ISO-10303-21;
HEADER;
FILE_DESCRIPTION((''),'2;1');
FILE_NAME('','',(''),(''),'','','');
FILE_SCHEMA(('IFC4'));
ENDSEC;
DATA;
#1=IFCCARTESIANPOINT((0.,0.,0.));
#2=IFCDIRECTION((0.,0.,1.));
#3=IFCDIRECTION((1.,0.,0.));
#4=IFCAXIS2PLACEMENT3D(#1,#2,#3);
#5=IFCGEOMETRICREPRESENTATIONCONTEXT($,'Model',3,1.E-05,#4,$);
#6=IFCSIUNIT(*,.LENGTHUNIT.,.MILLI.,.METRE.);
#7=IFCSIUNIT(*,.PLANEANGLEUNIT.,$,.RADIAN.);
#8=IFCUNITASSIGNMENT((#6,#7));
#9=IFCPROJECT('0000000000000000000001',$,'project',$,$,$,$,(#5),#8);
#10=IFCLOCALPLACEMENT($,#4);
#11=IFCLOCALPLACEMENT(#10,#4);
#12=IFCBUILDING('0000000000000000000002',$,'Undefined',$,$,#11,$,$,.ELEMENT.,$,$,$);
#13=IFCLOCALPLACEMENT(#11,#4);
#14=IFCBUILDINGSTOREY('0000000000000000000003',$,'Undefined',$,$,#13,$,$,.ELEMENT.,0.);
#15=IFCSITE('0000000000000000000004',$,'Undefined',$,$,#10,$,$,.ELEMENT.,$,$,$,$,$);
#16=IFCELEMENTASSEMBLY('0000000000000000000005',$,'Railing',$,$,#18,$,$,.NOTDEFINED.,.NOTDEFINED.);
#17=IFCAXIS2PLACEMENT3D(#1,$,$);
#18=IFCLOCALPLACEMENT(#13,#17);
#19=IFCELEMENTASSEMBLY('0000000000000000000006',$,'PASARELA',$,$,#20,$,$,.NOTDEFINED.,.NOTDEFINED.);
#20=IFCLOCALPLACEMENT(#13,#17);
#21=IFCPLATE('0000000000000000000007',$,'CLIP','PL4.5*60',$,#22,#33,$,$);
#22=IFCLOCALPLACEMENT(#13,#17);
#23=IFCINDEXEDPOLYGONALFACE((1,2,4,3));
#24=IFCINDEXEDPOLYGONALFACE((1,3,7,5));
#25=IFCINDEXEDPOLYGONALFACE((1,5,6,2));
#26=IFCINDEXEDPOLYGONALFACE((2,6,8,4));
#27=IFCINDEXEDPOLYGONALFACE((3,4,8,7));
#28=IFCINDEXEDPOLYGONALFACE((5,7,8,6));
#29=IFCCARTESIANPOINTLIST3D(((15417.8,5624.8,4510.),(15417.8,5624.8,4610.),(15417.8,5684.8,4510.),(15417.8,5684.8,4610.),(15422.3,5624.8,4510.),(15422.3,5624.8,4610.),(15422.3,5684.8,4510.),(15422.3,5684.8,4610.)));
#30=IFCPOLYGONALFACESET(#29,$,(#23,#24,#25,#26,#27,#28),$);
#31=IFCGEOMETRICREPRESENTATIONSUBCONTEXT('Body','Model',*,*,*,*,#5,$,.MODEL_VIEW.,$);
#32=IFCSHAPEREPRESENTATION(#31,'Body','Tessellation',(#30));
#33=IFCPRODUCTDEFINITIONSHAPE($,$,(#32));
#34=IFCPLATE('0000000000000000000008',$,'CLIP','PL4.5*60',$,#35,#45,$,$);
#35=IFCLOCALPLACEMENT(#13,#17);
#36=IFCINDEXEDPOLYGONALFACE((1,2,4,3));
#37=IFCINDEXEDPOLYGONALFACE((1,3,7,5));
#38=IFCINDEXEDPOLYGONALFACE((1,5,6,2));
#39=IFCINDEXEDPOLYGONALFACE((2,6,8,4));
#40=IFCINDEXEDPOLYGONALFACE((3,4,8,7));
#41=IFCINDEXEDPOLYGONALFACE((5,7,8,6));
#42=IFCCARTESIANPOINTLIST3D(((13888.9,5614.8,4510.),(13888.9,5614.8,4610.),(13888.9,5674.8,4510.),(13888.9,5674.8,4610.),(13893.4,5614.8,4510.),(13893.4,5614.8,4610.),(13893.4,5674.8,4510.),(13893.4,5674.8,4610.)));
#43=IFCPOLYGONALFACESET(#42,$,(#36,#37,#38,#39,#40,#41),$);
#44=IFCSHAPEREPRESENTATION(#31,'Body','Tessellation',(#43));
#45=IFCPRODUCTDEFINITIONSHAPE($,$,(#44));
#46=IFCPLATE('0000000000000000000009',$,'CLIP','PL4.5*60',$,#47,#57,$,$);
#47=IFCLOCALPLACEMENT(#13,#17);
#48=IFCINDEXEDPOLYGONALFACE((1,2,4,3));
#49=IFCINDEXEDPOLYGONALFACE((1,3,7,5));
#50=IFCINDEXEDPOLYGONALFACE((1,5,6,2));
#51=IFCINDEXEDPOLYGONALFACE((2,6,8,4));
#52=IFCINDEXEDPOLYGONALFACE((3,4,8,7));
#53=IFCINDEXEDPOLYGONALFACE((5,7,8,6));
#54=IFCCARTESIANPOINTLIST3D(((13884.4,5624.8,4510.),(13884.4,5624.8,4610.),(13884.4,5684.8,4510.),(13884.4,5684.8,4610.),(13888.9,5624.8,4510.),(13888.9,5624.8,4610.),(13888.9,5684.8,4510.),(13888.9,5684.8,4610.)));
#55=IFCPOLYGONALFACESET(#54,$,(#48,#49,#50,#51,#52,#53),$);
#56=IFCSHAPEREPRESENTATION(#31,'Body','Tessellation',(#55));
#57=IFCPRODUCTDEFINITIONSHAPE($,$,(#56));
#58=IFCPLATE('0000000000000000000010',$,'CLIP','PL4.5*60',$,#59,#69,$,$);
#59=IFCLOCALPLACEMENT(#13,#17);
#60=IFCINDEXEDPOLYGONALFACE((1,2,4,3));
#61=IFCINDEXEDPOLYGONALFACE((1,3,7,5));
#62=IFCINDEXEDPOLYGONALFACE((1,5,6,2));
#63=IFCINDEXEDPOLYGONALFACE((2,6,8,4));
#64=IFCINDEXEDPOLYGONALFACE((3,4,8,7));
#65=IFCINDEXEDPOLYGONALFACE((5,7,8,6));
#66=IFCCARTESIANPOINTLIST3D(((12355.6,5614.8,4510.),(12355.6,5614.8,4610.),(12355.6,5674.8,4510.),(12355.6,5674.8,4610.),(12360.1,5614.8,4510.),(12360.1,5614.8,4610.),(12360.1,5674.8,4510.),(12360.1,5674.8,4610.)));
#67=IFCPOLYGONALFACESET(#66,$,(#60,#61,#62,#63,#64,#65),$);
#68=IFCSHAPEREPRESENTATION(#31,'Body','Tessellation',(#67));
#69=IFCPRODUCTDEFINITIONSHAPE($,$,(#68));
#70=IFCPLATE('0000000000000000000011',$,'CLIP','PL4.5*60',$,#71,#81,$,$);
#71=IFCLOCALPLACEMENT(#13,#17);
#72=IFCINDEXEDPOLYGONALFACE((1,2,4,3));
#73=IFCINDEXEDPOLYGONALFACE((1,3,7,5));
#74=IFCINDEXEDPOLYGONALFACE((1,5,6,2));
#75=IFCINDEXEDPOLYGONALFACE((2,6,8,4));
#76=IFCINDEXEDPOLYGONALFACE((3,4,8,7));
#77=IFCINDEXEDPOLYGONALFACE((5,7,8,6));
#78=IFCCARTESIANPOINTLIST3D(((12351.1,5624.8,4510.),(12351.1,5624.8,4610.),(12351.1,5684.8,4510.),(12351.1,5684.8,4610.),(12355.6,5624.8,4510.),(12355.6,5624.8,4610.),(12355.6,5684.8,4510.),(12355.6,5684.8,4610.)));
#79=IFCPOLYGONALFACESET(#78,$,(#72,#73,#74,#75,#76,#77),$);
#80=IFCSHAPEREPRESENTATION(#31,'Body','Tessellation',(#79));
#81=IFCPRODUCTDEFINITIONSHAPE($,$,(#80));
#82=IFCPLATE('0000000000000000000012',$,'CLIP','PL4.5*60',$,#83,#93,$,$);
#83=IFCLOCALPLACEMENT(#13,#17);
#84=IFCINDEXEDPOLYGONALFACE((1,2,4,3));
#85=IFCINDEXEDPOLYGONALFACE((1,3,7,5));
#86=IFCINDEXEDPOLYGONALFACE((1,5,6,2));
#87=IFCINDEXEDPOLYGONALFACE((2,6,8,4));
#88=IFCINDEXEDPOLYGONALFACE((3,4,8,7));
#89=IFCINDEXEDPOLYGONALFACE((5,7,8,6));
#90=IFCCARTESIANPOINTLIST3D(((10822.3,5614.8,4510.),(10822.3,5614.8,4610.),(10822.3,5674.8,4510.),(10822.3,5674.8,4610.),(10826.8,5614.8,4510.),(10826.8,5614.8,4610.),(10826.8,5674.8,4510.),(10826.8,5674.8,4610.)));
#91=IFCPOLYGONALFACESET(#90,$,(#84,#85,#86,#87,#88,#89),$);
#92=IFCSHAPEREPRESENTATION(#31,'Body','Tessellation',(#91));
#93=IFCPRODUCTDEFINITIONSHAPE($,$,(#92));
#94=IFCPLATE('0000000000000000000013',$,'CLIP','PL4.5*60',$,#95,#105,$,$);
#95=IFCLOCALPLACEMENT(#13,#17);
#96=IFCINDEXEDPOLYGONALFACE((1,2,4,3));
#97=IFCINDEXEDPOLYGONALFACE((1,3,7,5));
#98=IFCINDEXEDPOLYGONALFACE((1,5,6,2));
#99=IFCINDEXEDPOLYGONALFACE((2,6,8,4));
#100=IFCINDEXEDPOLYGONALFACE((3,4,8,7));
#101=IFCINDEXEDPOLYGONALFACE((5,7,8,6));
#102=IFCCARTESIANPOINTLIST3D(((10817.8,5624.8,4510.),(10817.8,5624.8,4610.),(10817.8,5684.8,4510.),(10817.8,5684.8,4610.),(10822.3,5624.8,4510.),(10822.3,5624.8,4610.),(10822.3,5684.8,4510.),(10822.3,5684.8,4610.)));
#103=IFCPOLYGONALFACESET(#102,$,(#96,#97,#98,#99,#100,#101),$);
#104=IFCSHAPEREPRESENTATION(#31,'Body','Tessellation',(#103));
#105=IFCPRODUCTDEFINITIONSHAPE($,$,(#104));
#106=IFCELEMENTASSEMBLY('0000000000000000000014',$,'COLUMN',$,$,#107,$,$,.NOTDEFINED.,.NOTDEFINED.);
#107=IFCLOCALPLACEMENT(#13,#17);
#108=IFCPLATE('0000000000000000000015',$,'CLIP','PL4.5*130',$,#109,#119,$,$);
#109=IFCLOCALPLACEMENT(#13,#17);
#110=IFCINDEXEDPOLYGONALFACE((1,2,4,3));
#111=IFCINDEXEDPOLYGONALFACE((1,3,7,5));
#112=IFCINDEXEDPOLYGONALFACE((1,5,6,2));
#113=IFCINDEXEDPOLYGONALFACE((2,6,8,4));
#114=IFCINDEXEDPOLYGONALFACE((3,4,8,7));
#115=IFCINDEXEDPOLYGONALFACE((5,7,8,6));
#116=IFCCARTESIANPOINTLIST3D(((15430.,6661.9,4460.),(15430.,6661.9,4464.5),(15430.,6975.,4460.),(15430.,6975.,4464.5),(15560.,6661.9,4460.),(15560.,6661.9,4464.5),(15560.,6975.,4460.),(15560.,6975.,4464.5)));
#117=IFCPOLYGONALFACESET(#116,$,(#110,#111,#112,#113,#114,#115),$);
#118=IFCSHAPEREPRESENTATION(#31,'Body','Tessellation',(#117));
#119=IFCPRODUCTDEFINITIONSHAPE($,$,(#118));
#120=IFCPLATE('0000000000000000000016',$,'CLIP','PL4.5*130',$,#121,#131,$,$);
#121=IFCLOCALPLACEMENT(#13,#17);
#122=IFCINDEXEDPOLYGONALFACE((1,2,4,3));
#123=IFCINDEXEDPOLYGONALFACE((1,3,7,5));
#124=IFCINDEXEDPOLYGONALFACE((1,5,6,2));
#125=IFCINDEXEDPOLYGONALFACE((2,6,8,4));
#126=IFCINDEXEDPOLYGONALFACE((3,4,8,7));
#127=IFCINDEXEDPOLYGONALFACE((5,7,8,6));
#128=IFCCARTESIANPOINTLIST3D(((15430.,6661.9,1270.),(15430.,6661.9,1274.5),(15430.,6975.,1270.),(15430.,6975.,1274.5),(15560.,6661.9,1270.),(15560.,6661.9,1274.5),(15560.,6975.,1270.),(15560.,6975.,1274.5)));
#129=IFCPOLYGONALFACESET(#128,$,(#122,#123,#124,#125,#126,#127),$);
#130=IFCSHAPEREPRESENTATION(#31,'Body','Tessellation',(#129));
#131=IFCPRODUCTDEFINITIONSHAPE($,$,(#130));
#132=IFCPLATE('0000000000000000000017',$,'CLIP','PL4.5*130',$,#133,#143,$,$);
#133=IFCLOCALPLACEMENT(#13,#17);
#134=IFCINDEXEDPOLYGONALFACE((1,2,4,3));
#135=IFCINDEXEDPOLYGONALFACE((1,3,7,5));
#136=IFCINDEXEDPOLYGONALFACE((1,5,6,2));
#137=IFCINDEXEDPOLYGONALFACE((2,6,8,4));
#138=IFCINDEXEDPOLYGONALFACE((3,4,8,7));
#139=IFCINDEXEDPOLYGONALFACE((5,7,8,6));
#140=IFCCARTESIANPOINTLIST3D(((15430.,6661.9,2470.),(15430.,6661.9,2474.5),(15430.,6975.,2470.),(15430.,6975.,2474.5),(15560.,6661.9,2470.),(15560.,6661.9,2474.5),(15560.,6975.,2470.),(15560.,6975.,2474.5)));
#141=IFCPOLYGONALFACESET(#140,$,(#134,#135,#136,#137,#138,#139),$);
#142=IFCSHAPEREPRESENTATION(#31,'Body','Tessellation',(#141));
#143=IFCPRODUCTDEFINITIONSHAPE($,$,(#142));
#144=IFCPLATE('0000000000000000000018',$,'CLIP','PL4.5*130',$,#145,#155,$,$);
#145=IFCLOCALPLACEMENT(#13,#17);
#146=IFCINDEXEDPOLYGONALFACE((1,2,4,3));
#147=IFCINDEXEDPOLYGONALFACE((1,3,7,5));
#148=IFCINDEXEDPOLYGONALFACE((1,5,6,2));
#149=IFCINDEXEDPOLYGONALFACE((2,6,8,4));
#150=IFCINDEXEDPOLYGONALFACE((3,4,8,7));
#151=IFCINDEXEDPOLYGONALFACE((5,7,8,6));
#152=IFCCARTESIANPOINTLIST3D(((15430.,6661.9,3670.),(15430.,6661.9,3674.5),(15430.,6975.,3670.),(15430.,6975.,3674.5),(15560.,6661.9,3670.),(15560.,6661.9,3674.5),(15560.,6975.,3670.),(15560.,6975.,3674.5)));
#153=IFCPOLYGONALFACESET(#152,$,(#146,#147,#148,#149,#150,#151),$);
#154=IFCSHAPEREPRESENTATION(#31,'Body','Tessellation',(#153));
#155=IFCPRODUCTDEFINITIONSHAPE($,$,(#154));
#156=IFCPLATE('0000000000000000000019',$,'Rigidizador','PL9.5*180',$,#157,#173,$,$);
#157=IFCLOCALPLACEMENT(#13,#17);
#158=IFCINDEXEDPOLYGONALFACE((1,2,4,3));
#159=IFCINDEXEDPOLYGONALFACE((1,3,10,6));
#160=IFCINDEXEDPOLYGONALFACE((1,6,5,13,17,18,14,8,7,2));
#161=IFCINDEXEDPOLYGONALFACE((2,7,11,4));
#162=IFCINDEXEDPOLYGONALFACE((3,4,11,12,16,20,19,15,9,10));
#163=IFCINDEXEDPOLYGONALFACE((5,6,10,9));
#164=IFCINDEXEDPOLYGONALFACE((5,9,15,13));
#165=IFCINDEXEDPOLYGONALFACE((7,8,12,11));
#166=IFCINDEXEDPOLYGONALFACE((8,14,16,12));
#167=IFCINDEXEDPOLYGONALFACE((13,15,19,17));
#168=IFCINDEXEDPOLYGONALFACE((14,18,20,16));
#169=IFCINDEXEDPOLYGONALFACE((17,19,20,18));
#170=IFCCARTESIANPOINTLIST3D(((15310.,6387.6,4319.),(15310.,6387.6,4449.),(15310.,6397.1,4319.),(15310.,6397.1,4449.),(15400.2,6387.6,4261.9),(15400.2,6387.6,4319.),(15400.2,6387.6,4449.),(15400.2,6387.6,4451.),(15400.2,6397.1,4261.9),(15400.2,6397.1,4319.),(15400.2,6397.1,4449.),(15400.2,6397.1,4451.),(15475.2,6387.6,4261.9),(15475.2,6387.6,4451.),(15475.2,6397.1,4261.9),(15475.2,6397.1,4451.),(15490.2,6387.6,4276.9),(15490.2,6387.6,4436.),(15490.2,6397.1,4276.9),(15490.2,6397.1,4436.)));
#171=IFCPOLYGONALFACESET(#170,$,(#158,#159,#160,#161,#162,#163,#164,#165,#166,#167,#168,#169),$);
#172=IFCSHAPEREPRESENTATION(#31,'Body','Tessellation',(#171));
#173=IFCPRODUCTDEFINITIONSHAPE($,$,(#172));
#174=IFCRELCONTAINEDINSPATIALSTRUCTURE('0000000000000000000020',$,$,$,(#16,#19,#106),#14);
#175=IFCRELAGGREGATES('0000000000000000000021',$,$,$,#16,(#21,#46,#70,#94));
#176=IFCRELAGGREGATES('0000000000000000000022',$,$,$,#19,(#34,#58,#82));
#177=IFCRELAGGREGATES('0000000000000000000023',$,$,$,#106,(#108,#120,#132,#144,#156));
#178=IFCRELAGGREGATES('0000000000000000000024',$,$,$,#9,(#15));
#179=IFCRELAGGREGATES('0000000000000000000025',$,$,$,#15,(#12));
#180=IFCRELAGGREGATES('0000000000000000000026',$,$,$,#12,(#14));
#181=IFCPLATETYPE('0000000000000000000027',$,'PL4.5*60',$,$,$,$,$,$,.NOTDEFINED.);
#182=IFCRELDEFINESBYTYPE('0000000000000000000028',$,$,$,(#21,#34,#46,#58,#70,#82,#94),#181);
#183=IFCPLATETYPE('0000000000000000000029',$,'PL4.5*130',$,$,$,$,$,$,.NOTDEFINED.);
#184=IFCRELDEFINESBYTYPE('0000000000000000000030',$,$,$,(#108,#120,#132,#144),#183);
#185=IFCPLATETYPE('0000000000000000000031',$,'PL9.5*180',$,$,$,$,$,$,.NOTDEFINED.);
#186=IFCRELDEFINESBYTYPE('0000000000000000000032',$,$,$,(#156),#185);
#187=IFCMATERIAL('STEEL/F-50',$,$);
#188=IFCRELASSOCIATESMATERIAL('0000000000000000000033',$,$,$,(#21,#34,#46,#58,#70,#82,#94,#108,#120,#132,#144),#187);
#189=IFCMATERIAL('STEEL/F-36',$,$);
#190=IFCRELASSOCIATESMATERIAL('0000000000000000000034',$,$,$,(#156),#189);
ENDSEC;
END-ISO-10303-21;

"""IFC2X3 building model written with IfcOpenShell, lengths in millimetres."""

from ifc_helpers import new_model, si_unit, frame, origin_with_axes, place, context, subcontext, project, spatial, polyline, outline, extrude, material, type_object, element, aggregate, save


model = new_model("IFC2X3")

# Units and contexts
model_context = context("Model", 3, precision=1e-05, world=origin_with_axes())
body_context = subcontext(model_context, "Body", "Model", "MODEL_VIEW")
ifc_project = project(units=[si_unit("LENGTHUNIT", "METRE", prefix="MILLI"), si_unit("PLANEANGLEUNIT", "RADIAN")], contexts=[model_context])

# Site, building, storey
site_placement = place(None, origin_with_axes())
site = spatial("IfcSite", under=ifc_project, at=site_placement, Name="Undefined", CompositionType="ELEMENT")
building_placement = place(site_placement, origin_with_axes())
building = spatial("IfcBuilding", under=site, at=building_placement, Name="Undefined", CompositionType="ELEMENT")
storey_placement = place(building_placement, origin_with_axes())
storey = spatial("IfcBuildingStorey", under=building, at=storey_placement, Name="Undefined", CompositionType="ELEMENT", Elevation=0.0)

# Element assembly
assembly_1_placement = place(storey_placement, origin_with_axes())
assembly_1 = element("IfcElementAssembly", 1, at=assembly_1_placement, inside=storey, Name="Railing", AssemblyPlace="NOTDEFINED", PredefinedType="NOTDEFINED")

# Shared definitions
ifc_material_1 = material(Name="STEEL/F-36")

# Element assembly
assembly_2_placement = place(storey_placement, origin_with_axes())
assembly_2 = element("IfcElementAssembly", 2, at=assembly_2_placement, inside=storey, Name="PASARELA", AssemblyPlace="NOTDEFINED", PredefinedType="NOTDEFINED")
ifc_material_2 = material(Name="STEEL/F-50")
plate_type_1 = type_object("IfcPlateType", Name="PL4.5*60", PredefinedType="NOTDEFINED")

# Plates
plate_1_placement = place(assembly_1_placement, frame((15420.0, 5684.8, 4510.0), z_axis=(-1.0, 0.0, 0.0), x_axis=(0.000001, -1.0, 0.000014)))
plate_1 = element("IfcPlate", 3, at=plate_1_placement, type_object=plate_type_1, material=ifc_material_2, Name="CLIP", Description="PL4.5*60", context=body_context, shape_type="SweptSolid", body=[
    extrude(outline(polyline([(0.0, 0.0), (60.0, 0.0), (60.0, 100.0), (0.0, 100.0), (0.0, 0.0)])), frame((0.0, 0.0, -2.2), z_axis=(0.0, 0.0, 1.0), x_axis=(1.0, 0.0, 0.0)), (0.0, 0.0, 1.0), 4.5),
])
plate_2_placement = place(assembly_2_placement, frame((13891.2, 5674.8, 4510.0), z_axis=(-1.0, 0.0, 0.0), x_axis=(0.000001, -1.0, 0.000014)))
plate_2 = element("IfcPlate", 4, at=plate_2_placement, type_object=plate_type_1, material=ifc_material_2, Name="CLIP", Description="PL4.5*60", context=body_context, shape_type="SweptSolid", body=[
    extrude(outline(polyline([(0.0, 0.0), (60.0, 0.0), (60.0, 100.0), (0.0, 100.0), (0.0, 0.0)])), frame((0.0, 0.0, -2.2), z_axis=(0.0, 0.0, 1.0), x_axis=(1.0, 0.0, 0.0)), (0.0, 0.0, 1.0), 4.5),
])
plate_3_placement = place(assembly_1_placement, frame((13886.7, 5684.8, 4510.0), z_axis=(-1.0, 0.0, 0.0), x_axis=(0.000001, -1.0, 0.000014)))
plate_3 = element("IfcPlate", 5, at=plate_3_placement, type_object=plate_type_1, material=ifc_material_2, Name="CLIP", Description="PL4.5*60", context=body_context, shape_type="SweptSolid", body=[
    extrude(outline(polyline([(0.0, 0.0), (60.0, 0.0), (60.0, 100.0), (0.0, 100.0), (0.0, 0.0)])), frame((0.0, 0.0, -2.2), z_axis=(0.0, 0.0, 1.0), x_axis=(1.0, 0.0, 0.0)), (0.0, 0.0, 1.0), 4.5),
])
plate_4_placement = place(assembly_2_placement, frame((12357.8, 5674.8, 4510.0), z_axis=(-1.0, 0.0, 0.0), x_axis=(0.000001, -1.0, 0.000014)))
plate_4 = element("IfcPlate", 6, at=plate_4_placement, type_object=plate_type_1, material=ifc_material_2, Name="CLIP", Description="PL4.5*60", context=body_context, shape_type="SweptSolid", body=[
    extrude(outline(polyline([(0.0, 0.0), (60.0, 0.0), (60.0, 100.0), (0.0, 100.0), (0.0, 0.0)])), frame((0.0, 0.0, -2.2), z_axis=(0.0, 0.0, 1.0), x_axis=(1.0, 0.0, 0.0)), (0.0, 0.0, 1.0), 4.5),
])
plate_5_placement = place(assembly_1_placement, frame((12353.3, 5684.8, 4510.0), z_axis=(-1.0, 0.0, 0.0), x_axis=(0.000001, -1.0, 0.000014)))
plate_5 = element("IfcPlate", 7, at=plate_5_placement, type_object=plate_type_1, material=ifc_material_2, Name="CLIP", Description="PL4.5*60", context=body_context, shape_type="SweptSolid", body=[
    extrude(outline(polyline([(0.0, 0.0), (60.0, 0.0), (60.0, 100.0), (0.0, 100.0), (0.0, 0.0)])), frame((0.0, 0.0, -2.2), z_axis=(0.0, 0.0, 1.0), x_axis=(1.0, 0.0, 0.0)), (0.0, 0.0, 1.0), 4.5),
])
plate_6_placement = place(assembly_2_placement, frame((10824.5, 5674.8, 4510.0), z_axis=(-1.0, 0.0, 0.0), x_axis=(0.000001, -1.0, 0.000014)))
plate_6 = element("IfcPlate", 8, at=plate_6_placement, type_object=plate_type_1, material=ifc_material_2, Name="CLIP", Description="PL4.5*60", context=body_context, shape_type="SweptSolid", body=[
    extrude(outline(polyline([(0.0, 0.0), (60.0, 0.0), (60.0, 100.0), (0.0, 100.0), (0.0, 0.0)])), frame((0.0, 0.0, -2.2), z_axis=(0.0, 0.0, 1.0), x_axis=(1.0, 0.0, 0.0)), (0.0, 0.0, 1.0), 4.5),
])
plate_7_placement = place(assembly_1_placement, frame((10820.0, 5684.8, 4510.0), z_axis=(-1.0, 0.0, 0.0), x_axis=(0.000001, -1.0, 0.000014)))
plate_7 = element("IfcPlate", 9, at=plate_7_placement, type_object=plate_type_1, material=ifc_material_2, Name="CLIP", Description="PL4.5*60", context=body_context, shape_type="SweptSolid", body=[
    extrude(outline(polyline([(0.0, 0.0), (60.0, 0.0), (60.0, 100.0), (0.0, 100.0), (0.0, 0.0)])), frame((0.0, 0.0, -2.2), z_axis=(0.0, 0.0, 1.0), x_axis=(1.0, 0.0, 0.0)), (0.0, 0.0, 1.0), 4.5),
])
aggregate(assembly_1, [plate_1, plate_3, plate_5, plate_7])

# Element assembly, plates
assembly_3_placement = place(storey_placement, origin_with_axes())
assembly_3 = element("IfcElementAssembly", 10, at=assembly_3_placement, inside=storey, Name="COLUMN", AssemblyPlace="NOTDEFINED", PredefinedType="NOTDEFINED")
plate_type_2 = type_object("IfcPlateType", Name="PL4.5*130", PredefinedType="NOTDEFINED")
plate_8_placement = place(assembly_3_placement, frame((15430.0, 6975.0, 4462.3), z_axis=(0.0, 0.0, 1.0), x_axis=(0.0, -1.0, 0.0)))
plate_8 = element("IfcPlate", 11, at=plate_8_placement, type_object=plate_type_2, material=ifc_material_2, Name="CLIP", Description="PL4.5*130", context=body_context, shape_type="SweptSolid", body=[
    extrude(outline(polyline([(0.0, 0.0), (313.1, 0.0), (313.1, 130.0), (0.0, 130.0), (0.0, 0.0)])), frame((0.0, 0.0, -2.2), z_axis=(0.0, 0.0, 1.0), x_axis=(1.0, 0.0, 0.0)), (0.0, 0.0, 1.0), 4.5),
])
plate_9_placement = place(assembly_3_placement, frame((15430.0, 6975.0, 1272.2), z_axis=(0.0, 0.0, 1.0), x_axis=(0.0, -1.0, 0.0)))
plate_9 = element("IfcPlate", 12, at=plate_9_placement, type_object=plate_type_2, material=ifc_material_2, Name="CLIP", Description="PL4.5*130", context=body_context, shape_type="SweptSolid", body=[
    extrude(outline(polyline([(0.0, 0.0), (313.1, 0.0), (313.1, 130.0), (0.0, 130.0), (0.0, 0.0)])), frame((0.0, 0.0, -2.2), z_axis=(0.0, 0.0, 1.0), x_axis=(1.0, 0.0, 0.0)), (0.0, 0.0, 1.0), 4.5),
])
plate_10_placement = place(assembly_3_placement, frame((15430.0, 6975.0, 2472.2), z_axis=(0.0, 0.0, 1.0), x_axis=(0.0, -1.0, 0.0)))
plate_10 = element("IfcPlate", 13, at=plate_10_placement, type_object=plate_type_2, material=ifc_material_2, Name="CLIP", Description="PL4.5*130", context=body_context, shape_type="SweptSolid", body=[
    extrude(outline(polyline([(0.0, 0.0), (313.1, 0.0), (313.1, 130.0), (0.0, 130.0), (0.0, 0.0)])), frame((0.0, 0.0, -2.2), z_axis=(0.0, 0.0, 1.0), x_axis=(1.0, 0.0, 0.0)), (0.0, 0.0, 1.0), 4.5),
])
plate_11_placement = place(assembly_3_placement, frame((15430.0, 6975.0, 3672.2), z_axis=(0.0, 0.0, 1.0), x_axis=(0.0, -1.0, 0.0)))
plate_11 = element("IfcPlate", 14, at=plate_11_placement, type_object=plate_type_2, material=ifc_material_2, Name="CLIP", Description="PL4.5*130", context=body_context, shape_type="SweptSolid", body=[
    extrude(outline(polyline([(0.0, 0.0), (313.1, 0.0), (313.1, 130.0), (0.0, 130.0), (0.0, 0.0)])), frame((0.0, 0.0, -2.2), z_axis=(0.0, 0.0, 1.0), x_axis=(1.0, 0.0, 0.0)), (0.0, 0.0, 1.0), 4.5),
])
plate_type_3 = type_object("IfcPlateType", Name="PL9.5*180", PredefinedType="NOTDEFINED")
plate_12_placement = place(assembly_3_placement, frame((15400.2, 6392.4, 4451.0), z_axis=(0.0, 1.0, 0.0), x_axis=(1.0, 0.0, -0.000004)))
plate_12 = element("IfcPlate", 15, at=plate_12_placement, type_object=plate_type_3, material=ifc_material_1, Name="Rigidizador", Description="PL9.5*180", context=body_context, shape_type="SweptSolid", body=[
    extrude(outline(polyline([(0.0, 0.0), (75.0, 0.0), (90.0, 15.0), (90.0, 174.1), (75.0, 189.1), (0.0, 189.1), (0.0, 132.0), (-90.2, 132.0), (-90.2, 2.0), (0.0, 2.0), (0.0, 0.0)])), frame((0.0, 0.0, -4.8), z_axis=(0.0, 0.0, 1.0), x_axis=(1.0, 0.0, 0.0)), (0.0, 0.0, 1.0), 9.5),
])

aggregate(assembly_2, [plate_2, plate_4, plate_6])
aggregate(assembly_3, [plate_8, plate_9, plate_10, plate_11, plate_12])

save(model, "model.ifc")
